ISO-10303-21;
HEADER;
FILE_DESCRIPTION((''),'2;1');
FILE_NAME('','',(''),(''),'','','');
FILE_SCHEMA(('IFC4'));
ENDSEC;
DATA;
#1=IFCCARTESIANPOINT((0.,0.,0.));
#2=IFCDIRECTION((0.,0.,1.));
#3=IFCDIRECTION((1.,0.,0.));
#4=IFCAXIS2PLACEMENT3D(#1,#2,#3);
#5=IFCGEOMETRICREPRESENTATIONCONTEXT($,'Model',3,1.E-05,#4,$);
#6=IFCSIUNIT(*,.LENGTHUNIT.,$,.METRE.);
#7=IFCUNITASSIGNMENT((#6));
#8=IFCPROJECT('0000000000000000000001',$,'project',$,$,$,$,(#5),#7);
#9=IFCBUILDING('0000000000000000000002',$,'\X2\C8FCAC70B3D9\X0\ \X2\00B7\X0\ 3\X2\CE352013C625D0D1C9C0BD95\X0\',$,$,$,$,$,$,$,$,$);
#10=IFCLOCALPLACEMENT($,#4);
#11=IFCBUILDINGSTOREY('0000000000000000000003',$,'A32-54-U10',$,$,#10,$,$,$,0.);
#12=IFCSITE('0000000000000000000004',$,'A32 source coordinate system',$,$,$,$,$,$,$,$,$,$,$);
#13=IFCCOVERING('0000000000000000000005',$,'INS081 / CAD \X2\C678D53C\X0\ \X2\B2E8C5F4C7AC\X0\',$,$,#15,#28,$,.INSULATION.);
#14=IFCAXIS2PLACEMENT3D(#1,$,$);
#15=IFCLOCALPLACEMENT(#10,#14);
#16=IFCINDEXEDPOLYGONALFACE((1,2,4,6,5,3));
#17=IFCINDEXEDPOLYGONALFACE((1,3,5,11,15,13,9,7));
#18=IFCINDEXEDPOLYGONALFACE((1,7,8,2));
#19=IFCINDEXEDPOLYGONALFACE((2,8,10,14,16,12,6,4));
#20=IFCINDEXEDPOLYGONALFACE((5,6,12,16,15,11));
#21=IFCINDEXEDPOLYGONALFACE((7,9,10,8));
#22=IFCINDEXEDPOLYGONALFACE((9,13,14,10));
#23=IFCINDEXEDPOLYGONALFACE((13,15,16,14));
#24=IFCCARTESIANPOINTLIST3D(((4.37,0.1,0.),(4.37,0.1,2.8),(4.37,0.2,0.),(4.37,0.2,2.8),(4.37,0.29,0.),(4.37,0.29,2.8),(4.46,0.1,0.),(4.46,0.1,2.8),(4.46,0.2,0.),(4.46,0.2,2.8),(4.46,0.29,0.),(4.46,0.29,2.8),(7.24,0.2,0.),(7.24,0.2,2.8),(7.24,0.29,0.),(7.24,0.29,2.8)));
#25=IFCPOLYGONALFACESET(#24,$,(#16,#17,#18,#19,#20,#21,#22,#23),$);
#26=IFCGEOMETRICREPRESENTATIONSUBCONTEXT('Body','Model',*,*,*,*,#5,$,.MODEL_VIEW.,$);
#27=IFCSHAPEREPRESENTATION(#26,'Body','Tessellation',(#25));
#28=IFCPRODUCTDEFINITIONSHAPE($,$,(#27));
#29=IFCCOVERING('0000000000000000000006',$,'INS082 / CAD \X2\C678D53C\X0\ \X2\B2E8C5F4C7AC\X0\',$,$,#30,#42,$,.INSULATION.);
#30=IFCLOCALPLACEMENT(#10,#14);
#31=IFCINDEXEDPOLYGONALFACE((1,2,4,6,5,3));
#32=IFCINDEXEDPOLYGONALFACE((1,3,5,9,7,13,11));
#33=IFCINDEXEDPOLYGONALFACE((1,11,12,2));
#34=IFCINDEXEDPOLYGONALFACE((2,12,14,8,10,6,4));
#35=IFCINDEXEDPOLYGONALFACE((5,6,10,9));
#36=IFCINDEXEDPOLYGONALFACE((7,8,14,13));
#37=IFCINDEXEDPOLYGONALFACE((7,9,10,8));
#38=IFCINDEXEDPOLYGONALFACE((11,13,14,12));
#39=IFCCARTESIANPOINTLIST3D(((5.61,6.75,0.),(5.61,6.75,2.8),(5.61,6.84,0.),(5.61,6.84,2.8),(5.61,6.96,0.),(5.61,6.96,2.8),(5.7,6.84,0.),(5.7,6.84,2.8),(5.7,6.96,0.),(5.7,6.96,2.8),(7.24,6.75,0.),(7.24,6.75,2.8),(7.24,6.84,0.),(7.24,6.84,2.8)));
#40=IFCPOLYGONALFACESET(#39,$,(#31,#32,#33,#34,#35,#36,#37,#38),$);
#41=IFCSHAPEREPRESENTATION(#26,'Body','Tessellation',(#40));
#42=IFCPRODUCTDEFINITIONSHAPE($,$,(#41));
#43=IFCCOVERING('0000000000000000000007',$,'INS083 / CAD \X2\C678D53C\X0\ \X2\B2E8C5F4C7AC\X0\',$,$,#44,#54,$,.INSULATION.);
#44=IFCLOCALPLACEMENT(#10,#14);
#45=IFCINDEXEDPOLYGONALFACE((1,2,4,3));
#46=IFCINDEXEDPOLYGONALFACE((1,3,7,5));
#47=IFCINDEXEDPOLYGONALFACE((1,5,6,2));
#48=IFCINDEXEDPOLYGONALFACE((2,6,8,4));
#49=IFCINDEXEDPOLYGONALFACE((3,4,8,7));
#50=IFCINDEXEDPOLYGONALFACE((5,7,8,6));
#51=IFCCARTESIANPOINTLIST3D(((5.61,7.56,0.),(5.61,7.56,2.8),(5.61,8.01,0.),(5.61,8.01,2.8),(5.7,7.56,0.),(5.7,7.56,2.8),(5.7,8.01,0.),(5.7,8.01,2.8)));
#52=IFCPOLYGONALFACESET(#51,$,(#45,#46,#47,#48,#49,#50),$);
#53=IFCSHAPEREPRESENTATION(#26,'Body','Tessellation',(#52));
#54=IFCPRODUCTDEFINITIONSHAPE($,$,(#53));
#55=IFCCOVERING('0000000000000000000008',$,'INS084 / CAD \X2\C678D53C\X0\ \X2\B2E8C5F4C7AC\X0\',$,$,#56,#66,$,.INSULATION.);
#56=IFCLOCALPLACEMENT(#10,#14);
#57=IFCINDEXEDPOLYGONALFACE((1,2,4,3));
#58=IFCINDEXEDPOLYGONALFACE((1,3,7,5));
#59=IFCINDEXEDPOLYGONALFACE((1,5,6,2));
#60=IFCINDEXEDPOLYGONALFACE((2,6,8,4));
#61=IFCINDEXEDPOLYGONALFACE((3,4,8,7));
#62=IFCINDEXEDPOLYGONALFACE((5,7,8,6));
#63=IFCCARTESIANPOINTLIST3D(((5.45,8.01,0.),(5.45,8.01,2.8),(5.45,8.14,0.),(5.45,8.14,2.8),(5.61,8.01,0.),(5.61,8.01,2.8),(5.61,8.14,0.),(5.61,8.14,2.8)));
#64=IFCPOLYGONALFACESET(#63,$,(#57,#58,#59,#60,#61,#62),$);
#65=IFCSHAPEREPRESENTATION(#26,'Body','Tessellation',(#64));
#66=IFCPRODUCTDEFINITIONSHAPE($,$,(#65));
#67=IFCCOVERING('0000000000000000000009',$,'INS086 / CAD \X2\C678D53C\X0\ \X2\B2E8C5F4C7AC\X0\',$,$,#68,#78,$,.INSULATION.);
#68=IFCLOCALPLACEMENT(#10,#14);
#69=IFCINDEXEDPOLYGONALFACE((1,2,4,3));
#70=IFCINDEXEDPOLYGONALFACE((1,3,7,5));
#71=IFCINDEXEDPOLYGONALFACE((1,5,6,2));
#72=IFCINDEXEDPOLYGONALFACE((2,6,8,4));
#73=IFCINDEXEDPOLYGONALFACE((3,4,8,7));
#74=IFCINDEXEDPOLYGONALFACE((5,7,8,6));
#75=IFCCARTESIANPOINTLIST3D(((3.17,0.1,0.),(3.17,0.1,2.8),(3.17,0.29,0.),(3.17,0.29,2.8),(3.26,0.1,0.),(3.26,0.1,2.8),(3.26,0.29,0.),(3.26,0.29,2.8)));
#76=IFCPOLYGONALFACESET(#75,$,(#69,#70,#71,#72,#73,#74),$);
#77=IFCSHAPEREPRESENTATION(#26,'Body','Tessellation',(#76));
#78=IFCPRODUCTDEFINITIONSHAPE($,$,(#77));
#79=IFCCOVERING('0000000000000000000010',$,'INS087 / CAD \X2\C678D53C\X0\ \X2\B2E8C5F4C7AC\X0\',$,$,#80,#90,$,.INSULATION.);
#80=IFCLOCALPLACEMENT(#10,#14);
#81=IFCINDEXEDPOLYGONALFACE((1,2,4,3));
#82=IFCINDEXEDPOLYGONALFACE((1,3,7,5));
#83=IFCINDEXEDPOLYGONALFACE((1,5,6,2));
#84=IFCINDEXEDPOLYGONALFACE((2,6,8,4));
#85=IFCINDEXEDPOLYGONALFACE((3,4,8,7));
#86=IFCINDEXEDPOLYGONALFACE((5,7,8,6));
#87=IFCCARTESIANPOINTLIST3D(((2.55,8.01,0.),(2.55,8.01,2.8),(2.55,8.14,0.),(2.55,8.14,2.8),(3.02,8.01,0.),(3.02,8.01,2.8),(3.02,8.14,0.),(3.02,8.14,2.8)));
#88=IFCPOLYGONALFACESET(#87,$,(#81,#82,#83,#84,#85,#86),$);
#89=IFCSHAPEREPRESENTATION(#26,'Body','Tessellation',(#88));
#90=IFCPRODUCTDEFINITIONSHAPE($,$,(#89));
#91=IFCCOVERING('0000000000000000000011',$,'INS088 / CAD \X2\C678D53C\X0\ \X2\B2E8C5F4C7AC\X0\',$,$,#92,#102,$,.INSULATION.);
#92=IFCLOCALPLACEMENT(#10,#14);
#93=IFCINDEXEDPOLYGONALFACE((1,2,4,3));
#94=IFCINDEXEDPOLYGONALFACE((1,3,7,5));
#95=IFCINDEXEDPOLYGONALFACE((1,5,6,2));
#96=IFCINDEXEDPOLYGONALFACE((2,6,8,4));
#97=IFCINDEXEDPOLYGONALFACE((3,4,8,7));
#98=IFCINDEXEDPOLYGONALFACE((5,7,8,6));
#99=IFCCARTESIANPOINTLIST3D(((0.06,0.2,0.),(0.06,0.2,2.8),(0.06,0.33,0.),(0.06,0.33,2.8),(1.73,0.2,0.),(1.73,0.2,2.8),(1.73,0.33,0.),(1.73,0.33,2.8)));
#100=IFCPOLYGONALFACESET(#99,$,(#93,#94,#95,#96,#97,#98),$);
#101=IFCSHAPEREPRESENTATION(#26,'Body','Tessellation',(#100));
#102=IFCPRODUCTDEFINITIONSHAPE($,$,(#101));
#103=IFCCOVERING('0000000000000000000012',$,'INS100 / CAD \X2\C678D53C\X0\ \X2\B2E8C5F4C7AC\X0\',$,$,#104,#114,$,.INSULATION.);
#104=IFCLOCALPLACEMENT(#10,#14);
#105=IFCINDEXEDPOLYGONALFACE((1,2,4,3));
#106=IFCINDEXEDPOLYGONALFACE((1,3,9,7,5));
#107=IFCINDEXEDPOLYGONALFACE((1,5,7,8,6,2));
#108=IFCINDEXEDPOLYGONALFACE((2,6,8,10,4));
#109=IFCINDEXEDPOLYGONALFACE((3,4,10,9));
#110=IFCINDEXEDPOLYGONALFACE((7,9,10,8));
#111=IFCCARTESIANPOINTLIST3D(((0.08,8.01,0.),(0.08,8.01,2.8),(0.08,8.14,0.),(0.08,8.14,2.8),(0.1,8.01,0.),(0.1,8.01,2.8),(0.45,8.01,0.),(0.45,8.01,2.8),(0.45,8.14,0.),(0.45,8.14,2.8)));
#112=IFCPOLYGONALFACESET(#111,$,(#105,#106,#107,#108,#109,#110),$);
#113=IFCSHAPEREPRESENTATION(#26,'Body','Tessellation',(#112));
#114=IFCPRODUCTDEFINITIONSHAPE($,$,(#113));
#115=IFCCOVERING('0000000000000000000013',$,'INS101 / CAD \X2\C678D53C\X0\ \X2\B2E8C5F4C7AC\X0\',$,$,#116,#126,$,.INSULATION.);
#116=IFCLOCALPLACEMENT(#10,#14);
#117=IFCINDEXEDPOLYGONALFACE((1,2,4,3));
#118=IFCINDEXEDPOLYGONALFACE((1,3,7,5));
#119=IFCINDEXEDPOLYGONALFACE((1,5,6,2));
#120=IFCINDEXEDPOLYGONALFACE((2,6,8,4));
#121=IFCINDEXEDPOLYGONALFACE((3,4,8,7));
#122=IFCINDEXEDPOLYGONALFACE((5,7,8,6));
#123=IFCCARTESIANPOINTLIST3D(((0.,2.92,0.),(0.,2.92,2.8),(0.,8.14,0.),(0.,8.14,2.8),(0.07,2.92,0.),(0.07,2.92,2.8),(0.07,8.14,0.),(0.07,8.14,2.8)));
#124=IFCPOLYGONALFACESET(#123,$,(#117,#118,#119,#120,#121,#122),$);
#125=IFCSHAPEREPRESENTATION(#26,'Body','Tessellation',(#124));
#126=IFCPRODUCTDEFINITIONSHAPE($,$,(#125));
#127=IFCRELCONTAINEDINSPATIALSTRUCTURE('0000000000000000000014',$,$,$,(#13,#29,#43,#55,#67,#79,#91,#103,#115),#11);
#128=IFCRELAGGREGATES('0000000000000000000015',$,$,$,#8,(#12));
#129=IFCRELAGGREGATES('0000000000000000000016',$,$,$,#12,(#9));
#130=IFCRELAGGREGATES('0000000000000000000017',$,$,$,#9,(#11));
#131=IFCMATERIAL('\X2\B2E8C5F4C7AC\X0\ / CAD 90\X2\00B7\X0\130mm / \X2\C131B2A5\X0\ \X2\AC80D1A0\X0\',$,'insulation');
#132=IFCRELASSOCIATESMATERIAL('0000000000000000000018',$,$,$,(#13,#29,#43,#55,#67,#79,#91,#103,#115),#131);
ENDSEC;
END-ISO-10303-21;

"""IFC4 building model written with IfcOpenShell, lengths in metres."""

from ifc_helpers import new_model, si_unit, origin, origin_with_axes, place, context, subcontext, project, spatial, polyline, outline, extrude, material, element, save


model = new_model("IFC4")

# Units and contexts
model_context = context("Model", 3, precision=1e-05, world=origin_with_axes())
body_context = subcontext(model_context, "Body", "Model", "MODEL_VIEW")
ifc_project = project(units=[si_unit("LENGTHUNIT", "METRE")], contexts=[model_context])

# Site, building, storey
storey_placement = place(None, origin_with_axes())
site = spatial("IfcSite", under=ifc_project, Name="A32 source coordinate system")
building = spatial("IfcBuilding", under=site, Name="주거동 · 3층–옥탑지붕")
storey = spatial("IfcBuildingStorey", under=building, at=storey_placement, Name="A32-54-U10", Elevation=0.0)

# Coverings
ifc_material = material(Name="단열재 / CAD 90·130mm / 성능 검토", Category="insulation")
covering_1_placement = place(storey_placement, origin_with_axes())
element("IfcCovering", 1, at=covering_1_placement, inside=storey, material=ifc_material, Name="INS081 / CAD 외피 단열재", PredefinedType="INSULATION", context=body_context, shape_type="SweptSolid", body=[
    extrude(outline(polyline([(4.37, 0.2), (4.37, 0.29), (4.46, 0.29), (7.24, 0.29), (7.24, 0.2), (4.46, 0.2), (4.46, 0.1), (4.37, 0.1), (4.37, 0.2)])), origin(), (0.0, 0.0, 1.0), 2.8),
])
covering_2_placement = place(storey_placement, origin_with_axes())
element("IfcCovering", 2, at=covering_2_placement, inside=storey, material=ifc_material, Name="INS082 / CAD 외피 단열재", PredefinedType="INSULATION", context=body_context, shape_type="SweptSolid", body=[
    extrude(outline(polyline([(5.61, 6.84), (5.61, 6.96), (5.7, 6.96), (5.7, 6.84), (7.24, 6.84), (7.24, 6.75), (5.61, 6.75), (5.61, 6.84)])), origin(), (0.0, 0.0, 1.0), 2.8),
])
covering_3_placement = place(storey_placement, origin_with_axes())
element("IfcCovering", 3, at=covering_3_placement, inside=storey, material=ifc_material, Name="INS083 / CAD 외피 단열재", PredefinedType="INSULATION", context=body_context, shape_type="SweptSolid", body=[
    extrude(outline(polyline([(5.61, 8.01), (5.7, 8.01), (5.7, 7.56), (5.61, 7.56), (5.61, 8.01)])), origin(), (0.0, 0.0, 1.0), 2.8),
])
covering_4_placement = place(storey_placement, origin_with_axes())
element("IfcCovering", 4, at=covering_4_placement, inside=storey, material=ifc_material, Name="INS084 / CAD 외피 단열재", PredefinedType="INSULATION", context=body_context, shape_type="SweptSolid", body=[
    extrude(outline(polyline([(5.45, 8.01), (5.45, 8.14), (5.61, 8.14), (5.61, 8.01), (5.45, 8.01)])), origin(), (0.0, 0.0, 1.0), 2.8),
])
covering_5_placement = place(storey_placement, origin_with_axes())
element("IfcCovering", 5, at=covering_5_placement, inside=storey, material=ifc_material, Name="INS086 / CAD 외피 단열재", PredefinedType="INSULATION", context=body_context, shape_type="SweptSolid", body=[
    extrude(outline(polyline([(3.17, 0.1), (3.17, 0.29), (3.26, 0.29), (3.26, 0.1), (3.17, 0.1)])), origin(), (0.0, 0.0, 1.0), 2.8),
])
covering_6_placement = place(storey_placement, origin_with_axes())
element("IfcCovering", 6, at=covering_6_placement, inside=storey, material=ifc_material, Name="INS087 / CAD 외피 단열재", PredefinedType="INSULATION", context=body_context, shape_type="SweptSolid", body=[
    extrude(outline(polyline([(2.55, 8.14), (3.02, 8.14), (3.02, 8.01), (2.55, 8.01), (2.55, 8.14)])), origin(), (0.0, 0.0, 1.0), 2.8),
])
covering_7_placement = place(storey_placement, origin_with_axes())
element("IfcCovering", 7, at=covering_7_placement, inside=storey, material=ifc_material, Name="INS088 / CAD 외피 단열재", PredefinedType="INSULATION", context=body_context, shape_type="SweptSolid", body=[
    extrude(outline(polyline([(0.06, 0.33), (1.73, 0.33), (1.73, 0.2), (0.06, 0.2), (0.06, 0.33)])), origin(), (0.0, 0.0, 1.0), 2.8),
])
covering_8_placement = place(storey_placement, origin_with_axes())
element("IfcCovering", 8, at=covering_8_placement, inside=storey, material=ifc_material, Name="INS100 / CAD 외피 단열재", PredefinedType="INSULATION", context=body_context, shape_type="SweptSolid", body=[
    extrude(outline(polyline([(0.08, 8.01), (0.08, 8.14), (0.45, 8.14), (0.45, 8.01), (0.1, 8.01), (0.08, 8.01)])), origin(), (0.0, 0.0, 1.0), 2.8),
])
covering_9_placement = place(storey_placement, origin_with_axes())
element("IfcCovering", 9, at=covering_9_placement, inside=storey, material=ifc_material, Name="INS101 / CAD 외피 단열재", PredefinedType="INSULATION", context=body_context, shape_type="SweptSolid", body=[
    extrude(outline(polyline([(0.0, 2.92), (0.0, 8.14), (0.07, 8.14), (0.07, 2.92), (0.0, 2.92)])), origin(), (0.0, 0.0, 1.0), 2.8),
])

save(model, "model.ifc")
